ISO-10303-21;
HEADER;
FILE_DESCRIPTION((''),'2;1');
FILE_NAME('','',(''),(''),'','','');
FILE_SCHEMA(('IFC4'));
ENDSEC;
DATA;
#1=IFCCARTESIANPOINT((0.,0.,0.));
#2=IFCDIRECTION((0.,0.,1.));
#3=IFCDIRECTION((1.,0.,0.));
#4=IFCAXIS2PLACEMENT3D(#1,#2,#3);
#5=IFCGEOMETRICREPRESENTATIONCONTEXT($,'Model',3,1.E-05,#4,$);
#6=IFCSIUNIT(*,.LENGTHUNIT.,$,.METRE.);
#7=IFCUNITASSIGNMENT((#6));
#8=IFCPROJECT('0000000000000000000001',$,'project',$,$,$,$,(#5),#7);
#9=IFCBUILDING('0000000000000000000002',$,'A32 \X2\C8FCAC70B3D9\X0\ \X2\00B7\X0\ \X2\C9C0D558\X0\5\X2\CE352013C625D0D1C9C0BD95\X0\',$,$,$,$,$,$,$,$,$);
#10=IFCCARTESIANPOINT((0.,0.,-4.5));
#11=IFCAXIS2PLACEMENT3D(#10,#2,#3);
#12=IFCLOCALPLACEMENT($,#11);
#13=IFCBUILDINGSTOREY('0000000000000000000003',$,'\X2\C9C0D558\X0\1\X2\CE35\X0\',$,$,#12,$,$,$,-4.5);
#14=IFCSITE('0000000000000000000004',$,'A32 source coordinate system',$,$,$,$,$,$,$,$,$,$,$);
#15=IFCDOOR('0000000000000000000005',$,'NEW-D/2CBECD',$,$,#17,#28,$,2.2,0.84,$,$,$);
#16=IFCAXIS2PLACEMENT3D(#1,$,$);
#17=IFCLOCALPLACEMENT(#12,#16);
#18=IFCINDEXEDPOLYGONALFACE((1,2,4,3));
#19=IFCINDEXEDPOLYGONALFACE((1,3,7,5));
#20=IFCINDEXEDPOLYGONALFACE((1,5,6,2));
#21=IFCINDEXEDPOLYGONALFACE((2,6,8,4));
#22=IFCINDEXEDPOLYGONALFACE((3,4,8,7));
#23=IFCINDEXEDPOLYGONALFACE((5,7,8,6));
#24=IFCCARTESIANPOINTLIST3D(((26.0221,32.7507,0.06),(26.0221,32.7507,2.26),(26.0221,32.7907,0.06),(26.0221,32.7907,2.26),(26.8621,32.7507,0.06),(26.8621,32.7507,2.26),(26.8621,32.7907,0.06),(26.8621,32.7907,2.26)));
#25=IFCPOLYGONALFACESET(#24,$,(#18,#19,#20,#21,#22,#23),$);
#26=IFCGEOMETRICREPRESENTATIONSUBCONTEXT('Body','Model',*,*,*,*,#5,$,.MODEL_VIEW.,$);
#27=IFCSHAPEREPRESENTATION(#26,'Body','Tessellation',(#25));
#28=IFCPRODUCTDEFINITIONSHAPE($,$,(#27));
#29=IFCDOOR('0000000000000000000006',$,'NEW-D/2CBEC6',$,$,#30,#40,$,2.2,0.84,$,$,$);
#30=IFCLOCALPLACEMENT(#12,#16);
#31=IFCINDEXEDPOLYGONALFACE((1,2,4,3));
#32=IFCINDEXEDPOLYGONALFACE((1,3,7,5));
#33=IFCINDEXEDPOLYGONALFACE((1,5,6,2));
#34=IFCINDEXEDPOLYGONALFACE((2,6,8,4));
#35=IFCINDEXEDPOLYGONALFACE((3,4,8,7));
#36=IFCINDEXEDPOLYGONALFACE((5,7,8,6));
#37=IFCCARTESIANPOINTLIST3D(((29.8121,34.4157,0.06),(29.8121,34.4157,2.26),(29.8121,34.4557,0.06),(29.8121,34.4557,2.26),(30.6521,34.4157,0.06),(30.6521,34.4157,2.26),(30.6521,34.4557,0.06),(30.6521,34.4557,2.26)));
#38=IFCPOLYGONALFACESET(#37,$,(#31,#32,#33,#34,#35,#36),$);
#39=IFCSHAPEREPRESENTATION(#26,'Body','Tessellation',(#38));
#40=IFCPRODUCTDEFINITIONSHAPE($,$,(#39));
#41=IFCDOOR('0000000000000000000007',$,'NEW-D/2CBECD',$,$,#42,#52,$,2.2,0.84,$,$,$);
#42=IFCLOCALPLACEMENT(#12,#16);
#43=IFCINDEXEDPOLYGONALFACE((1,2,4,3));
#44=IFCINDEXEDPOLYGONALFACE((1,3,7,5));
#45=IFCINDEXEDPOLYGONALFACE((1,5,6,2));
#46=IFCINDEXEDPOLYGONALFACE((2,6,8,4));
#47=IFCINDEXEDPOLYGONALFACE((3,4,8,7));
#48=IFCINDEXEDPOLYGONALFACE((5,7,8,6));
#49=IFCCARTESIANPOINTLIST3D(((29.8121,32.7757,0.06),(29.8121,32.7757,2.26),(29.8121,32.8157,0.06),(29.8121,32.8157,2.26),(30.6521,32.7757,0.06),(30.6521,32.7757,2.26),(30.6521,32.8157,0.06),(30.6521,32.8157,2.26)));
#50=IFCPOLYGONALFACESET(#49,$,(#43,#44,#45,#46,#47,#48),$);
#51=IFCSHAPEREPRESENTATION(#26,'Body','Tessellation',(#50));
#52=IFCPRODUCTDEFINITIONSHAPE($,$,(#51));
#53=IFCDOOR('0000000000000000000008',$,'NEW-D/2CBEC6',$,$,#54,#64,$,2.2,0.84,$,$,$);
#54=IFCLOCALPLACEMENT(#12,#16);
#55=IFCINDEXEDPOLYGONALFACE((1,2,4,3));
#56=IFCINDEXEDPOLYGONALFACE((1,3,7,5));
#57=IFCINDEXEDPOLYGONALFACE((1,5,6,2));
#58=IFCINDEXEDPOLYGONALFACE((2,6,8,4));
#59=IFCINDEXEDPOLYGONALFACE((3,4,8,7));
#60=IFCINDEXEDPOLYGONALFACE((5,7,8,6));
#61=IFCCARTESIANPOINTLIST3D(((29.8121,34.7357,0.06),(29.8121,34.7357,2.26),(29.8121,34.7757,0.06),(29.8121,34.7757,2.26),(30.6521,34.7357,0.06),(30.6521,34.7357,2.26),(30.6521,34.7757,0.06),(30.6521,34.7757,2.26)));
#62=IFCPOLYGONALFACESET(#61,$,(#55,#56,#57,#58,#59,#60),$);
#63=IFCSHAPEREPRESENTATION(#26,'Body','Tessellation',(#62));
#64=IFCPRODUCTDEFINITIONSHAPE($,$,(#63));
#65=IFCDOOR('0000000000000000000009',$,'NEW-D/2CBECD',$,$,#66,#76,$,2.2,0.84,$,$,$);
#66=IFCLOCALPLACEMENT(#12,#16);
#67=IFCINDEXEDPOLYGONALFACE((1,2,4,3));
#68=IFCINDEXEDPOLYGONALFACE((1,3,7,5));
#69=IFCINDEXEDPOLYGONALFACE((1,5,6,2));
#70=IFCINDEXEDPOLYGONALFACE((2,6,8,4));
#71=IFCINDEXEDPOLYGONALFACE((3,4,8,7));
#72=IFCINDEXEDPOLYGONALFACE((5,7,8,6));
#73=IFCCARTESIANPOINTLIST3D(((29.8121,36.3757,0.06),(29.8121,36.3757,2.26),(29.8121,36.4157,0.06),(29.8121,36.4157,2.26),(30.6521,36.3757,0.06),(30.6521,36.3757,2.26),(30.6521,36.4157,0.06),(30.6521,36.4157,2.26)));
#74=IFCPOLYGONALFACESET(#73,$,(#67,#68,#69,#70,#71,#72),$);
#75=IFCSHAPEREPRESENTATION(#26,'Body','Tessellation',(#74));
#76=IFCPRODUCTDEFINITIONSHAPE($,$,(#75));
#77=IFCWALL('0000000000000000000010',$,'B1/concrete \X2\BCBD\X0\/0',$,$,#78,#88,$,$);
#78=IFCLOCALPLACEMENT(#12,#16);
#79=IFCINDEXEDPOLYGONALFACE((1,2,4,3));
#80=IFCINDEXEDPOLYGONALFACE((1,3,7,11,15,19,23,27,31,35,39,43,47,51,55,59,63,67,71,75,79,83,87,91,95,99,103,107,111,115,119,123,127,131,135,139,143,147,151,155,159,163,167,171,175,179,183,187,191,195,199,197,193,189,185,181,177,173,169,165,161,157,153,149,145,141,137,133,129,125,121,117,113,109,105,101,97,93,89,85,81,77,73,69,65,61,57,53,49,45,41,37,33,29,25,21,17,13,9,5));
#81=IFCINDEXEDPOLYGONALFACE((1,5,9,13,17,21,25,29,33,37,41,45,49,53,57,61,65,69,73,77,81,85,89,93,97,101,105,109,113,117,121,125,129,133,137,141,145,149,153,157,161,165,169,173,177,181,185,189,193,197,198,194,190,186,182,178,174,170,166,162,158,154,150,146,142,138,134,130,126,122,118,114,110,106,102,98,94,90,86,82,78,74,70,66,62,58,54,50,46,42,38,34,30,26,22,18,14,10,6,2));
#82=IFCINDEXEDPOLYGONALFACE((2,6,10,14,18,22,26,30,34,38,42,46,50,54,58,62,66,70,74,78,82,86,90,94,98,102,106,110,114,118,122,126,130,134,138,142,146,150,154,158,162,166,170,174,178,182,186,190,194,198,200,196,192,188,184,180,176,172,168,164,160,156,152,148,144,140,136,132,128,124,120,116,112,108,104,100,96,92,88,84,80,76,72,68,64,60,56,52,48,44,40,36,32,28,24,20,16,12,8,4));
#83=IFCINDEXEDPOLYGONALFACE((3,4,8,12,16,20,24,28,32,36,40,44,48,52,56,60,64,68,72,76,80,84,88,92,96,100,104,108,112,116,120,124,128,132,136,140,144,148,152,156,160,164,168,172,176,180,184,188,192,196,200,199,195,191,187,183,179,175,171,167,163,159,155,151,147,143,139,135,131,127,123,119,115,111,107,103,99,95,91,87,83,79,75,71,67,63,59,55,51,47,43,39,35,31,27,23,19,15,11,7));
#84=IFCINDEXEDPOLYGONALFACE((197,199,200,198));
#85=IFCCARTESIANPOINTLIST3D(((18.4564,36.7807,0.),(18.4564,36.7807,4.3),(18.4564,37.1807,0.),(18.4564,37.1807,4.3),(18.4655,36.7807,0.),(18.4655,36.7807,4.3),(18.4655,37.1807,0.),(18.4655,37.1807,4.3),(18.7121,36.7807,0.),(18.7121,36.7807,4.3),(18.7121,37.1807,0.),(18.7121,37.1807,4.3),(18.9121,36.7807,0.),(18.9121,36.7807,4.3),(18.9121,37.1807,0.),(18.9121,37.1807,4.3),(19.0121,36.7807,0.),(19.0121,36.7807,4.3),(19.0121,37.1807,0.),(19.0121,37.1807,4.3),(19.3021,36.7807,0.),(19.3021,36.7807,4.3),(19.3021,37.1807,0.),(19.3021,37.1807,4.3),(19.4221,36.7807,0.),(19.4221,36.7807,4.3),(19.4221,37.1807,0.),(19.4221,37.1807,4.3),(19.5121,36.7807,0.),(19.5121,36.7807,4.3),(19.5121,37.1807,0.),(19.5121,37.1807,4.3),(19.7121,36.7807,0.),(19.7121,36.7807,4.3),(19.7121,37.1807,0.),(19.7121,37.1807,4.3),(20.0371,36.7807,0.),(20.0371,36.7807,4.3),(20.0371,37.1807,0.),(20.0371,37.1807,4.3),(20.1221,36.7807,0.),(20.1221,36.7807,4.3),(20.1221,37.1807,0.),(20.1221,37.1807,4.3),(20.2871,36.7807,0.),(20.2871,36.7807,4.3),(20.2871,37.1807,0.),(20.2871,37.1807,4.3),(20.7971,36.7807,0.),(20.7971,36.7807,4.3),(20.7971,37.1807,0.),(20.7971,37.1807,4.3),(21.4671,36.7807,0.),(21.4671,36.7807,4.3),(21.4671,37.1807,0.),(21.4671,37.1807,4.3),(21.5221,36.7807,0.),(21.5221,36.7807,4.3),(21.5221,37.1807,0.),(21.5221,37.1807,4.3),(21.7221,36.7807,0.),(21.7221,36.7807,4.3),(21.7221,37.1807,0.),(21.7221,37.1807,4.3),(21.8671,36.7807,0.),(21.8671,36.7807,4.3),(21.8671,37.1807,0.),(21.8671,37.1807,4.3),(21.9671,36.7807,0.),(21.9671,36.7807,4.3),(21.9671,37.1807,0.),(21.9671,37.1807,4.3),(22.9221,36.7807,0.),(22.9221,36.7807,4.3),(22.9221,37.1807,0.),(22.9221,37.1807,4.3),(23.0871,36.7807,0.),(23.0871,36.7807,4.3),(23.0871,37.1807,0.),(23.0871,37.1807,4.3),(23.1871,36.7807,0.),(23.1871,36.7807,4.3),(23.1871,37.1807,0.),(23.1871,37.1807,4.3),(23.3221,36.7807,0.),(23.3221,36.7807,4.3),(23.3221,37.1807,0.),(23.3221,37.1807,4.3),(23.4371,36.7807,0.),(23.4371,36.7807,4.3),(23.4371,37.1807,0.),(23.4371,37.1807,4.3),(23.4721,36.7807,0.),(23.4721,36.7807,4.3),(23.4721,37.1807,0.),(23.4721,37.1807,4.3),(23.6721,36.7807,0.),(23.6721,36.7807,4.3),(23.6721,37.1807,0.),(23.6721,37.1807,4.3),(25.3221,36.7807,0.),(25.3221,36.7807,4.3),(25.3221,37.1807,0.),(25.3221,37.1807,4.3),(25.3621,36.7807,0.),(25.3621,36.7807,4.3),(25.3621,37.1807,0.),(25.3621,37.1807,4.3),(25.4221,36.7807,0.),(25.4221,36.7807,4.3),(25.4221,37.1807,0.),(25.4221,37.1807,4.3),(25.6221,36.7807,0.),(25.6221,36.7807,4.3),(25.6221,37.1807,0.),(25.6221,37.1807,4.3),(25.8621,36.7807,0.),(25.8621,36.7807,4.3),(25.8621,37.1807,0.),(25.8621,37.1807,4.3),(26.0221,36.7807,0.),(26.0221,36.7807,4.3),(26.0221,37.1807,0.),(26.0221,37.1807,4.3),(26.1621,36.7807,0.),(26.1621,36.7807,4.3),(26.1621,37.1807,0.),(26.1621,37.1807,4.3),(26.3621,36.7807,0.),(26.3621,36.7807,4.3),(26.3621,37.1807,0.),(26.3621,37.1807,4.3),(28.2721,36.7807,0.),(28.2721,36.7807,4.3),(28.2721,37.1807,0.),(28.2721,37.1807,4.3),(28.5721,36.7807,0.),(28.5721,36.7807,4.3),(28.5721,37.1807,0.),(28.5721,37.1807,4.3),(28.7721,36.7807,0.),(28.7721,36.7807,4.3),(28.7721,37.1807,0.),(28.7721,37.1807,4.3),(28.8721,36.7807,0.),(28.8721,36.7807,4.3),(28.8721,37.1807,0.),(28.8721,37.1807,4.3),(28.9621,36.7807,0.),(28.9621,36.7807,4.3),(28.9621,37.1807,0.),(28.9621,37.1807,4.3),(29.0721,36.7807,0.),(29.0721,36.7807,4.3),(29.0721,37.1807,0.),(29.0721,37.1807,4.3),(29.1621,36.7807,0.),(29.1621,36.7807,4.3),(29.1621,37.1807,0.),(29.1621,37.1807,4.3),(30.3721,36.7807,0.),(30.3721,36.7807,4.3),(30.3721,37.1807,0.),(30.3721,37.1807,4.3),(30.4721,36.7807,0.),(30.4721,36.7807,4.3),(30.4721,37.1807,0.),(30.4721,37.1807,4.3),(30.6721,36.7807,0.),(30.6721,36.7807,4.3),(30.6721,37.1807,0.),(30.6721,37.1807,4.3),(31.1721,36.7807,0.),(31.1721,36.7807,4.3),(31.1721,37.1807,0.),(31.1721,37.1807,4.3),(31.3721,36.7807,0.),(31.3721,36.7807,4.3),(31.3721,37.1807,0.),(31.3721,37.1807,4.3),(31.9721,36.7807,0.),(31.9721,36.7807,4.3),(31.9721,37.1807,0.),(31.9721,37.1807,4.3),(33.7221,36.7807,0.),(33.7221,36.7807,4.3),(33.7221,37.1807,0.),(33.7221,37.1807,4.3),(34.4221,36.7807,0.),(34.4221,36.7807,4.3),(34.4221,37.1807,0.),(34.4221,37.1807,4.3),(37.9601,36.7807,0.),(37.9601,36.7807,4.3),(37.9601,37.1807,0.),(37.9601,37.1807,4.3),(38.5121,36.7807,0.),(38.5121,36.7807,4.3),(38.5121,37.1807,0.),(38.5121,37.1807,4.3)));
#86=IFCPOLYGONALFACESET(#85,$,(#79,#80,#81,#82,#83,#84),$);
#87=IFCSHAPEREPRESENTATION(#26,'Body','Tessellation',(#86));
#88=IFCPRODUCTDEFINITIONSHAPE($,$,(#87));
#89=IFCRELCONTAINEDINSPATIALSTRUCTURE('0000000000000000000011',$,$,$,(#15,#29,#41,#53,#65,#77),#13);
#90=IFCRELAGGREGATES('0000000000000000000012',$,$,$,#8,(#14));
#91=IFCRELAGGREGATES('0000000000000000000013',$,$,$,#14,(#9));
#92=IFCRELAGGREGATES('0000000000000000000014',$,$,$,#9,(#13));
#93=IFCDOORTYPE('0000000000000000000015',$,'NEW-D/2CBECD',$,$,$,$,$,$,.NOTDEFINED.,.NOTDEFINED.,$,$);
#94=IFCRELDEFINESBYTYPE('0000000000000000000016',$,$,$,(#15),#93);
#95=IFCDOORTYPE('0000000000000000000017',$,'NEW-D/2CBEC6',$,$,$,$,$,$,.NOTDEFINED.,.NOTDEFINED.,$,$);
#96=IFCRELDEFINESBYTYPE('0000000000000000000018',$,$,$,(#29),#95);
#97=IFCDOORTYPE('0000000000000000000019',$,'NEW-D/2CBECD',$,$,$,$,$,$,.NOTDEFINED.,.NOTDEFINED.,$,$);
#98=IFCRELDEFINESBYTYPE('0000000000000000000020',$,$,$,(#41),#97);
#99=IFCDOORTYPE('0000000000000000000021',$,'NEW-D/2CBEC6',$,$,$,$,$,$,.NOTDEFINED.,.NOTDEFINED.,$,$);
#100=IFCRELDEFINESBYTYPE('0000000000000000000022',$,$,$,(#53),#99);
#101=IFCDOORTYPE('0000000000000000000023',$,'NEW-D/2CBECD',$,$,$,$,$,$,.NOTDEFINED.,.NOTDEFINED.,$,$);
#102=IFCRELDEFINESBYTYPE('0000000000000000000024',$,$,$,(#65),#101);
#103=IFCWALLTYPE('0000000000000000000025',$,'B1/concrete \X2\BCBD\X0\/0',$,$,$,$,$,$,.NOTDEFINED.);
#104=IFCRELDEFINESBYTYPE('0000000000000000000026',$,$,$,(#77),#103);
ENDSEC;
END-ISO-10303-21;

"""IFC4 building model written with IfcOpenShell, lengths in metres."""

from ifc_helpers import new_model, si_unit, frame, origin, origin_with_axes, place, context, subcontext, project, spatial, polyline, outline, extrude, source, transform, mapped, type_object, type_shapes, element, save


model = new_model("IFC4")

# Units and contexts
model_context = context("Model", 3, precision=1e-05, world=origin_with_axes())
body_context = subcontext(model_context, "Body", "Model", "MODEL_VIEW")
ifc_project = project(units=[si_unit("LENGTHUNIT", "METRE")], contexts=[model_context])

# Site, building, storey
storey_placement = place(None, frame((0.0, 0.0, -4.5), z_axis=(0.0, 0.0, 1.0), x_axis=(1.0, 0.0, 0.0)))
site = spatial("IfcSite", under=ifc_project, Name="A32 source coordinate system")
building = spatial("IfcBuilding", under=site, Name="A32 주거동 · 지하5층–옥탑지붕")
storey = spatial("IfcBuildingStorey", under=building, at=storey_placement, Name="지하1층", Elevation=-4.5)

# Doors
door_type_1 = type_object("IfcDoorType", Name="NEW-D/2CBECD", OperationType="NOTDEFINED", PredefinedType="NOTDEFINED")
shared_shape_1 = source(origin(), body_context, "Body", "SweptSolid", [
    extrude(outline(polyline([(26.8621, 32.7507), (26.0221, 32.7507), (26.0221, 32.7907), (26.8621, 32.7907), (26.8621, 32.7507)])), frame((0.0, 0.0, 0.06)), (0.0, 0.0, 1.0), 2.2),
])
type_shapes(door_type_1, [shared_shape_1])
door_1_placement = place(storey_placement, origin_with_axes())
element("IfcDoor", 1, at=door_1_placement, inside=storey, type_object=door_type_1, Name="NEW-D/2CBECD", OverallHeight=2.2, OverallWidth=0.84, context=body_context, shape_type="MappedRepresentation", body=[
    mapped(shared_shape_1, transform((0.0, 0.0, 0.0), scale=1.0)),
])
door_type_2 = type_object("IfcDoorType", Name="NEW-D/2CBEC6", OperationType="NOTDEFINED", PredefinedType="NOTDEFINED")
shared_shape_2 = source(origin(), body_context, "Body", "SweptSolid", [
    extrude(outline(polyline([(29.8121, 34.4557), (30.6521, 34.4557), (30.6521, 34.4157), (29.8121, 34.4157), (29.8121, 34.4557)])), frame((0.0, 0.0, 0.06)), (0.0, 0.0, 1.0), 2.2),
])
type_shapes(door_type_2, [shared_shape_2])
door_2_placement = place(storey_placement, origin_with_axes())
element("IfcDoor", 2, at=door_2_placement, inside=storey, type_object=door_type_2, Name="NEW-D/2CBEC6", OverallHeight=2.2, OverallWidth=0.84, context=body_context, shape_type="MappedRepresentation", body=[
    mapped(shared_shape_2, transform((0.0, 0.0, 0.0), scale=1.0)),
])
door_type_3 = type_object("IfcDoorType", Name="NEW-D/2CBECD", OperationType="NOTDEFINED", PredefinedType="NOTDEFINED")
shared_shape_3 = source(origin(), body_context, "Body", "SweptSolid", [
    extrude(outline(polyline([(30.6521, 32.8157), (30.6521, 32.7757), (29.8121, 32.7757), (29.8121, 32.8157), (30.6521, 32.8157)])), frame((0.0, 0.0, 0.06)), (0.0, 0.0, 1.0), 2.2),
])
type_shapes(door_type_3, [shared_shape_3])
door_3_placement = place(storey_placement, origin_with_axes())
element("IfcDoor", 3, at=door_3_placement, inside=storey, type_object=door_type_3, Name="NEW-D/2CBECD", OverallHeight=2.2, OverallWidth=0.84, context=body_context, shape_type="MappedRepresentation", body=[
    mapped(shared_shape_3, transform((0.0, 0.0, 0.0), scale=1.0)),
])
door_type_4 = type_object("IfcDoorType", Name="NEW-D/2CBEC6", OperationType="NOTDEFINED", PredefinedType="NOTDEFINED")
shared_shape_4 = source(origin(), body_context, "Body", "SweptSolid", [
    extrude(outline(polyline([(30.6521, 34.7757), (30.6521, 34.7357), (29.8121, 34.7357), (29.8121, 34.7757), (30.6521, 34.7757)])), frame((0.0, 0.0, 0.06)), (0.0, 0.0, 1.0), 2.2),
])
type_shapes(door_type_4, [shared_shape_4])
door_4_placement = place(storey_placement, origin_with_axes())
element("IfcDoor", 4, at=door_4_placement, inside=storey, type_object=door_type_4, Name="NEW-D/2CBEC6", OverallHeight=2.2, OverallWidth=0.84, context=body_context, shape_type="MappedRepresentation", body=[
    mapped(shared_shape_4, transform((0.0, 0.0, 0.0), scale=1.0)),
])
door_type_5 = type_object("IfcDoorType", Name="NEW-D/2CBECD", OperationType="NOTDEFINED", PredefinedType="NOTDEFINED")
shared_shape_5 = source(origin(), body_context, "Body", "SweptSolid", [
    extrude(outline(polyline([(29.8121, 36.4157), (30.6521, 36.4157), (30.6521, 36.3757), (29.8121, 36.3757), (29.8121, 36.4157)])), frame((0.0, 0.0, 0.06)), (0.0, 0.0, 1.0), 2.2),
])
type_shapes(door_type_5, [shared_shape_5])
door_5_placement = place(storey_placement, origin_with_axes())
element("IfcDoor", 5, at=door_5_placement, inside=storey, type_object=door_type_5, Name="NEW-D/2CBECD", OverallHeight=2.2, OverallWidth=0.84, context=body_context, shape_type="MappedRepresentation", body=[
    mapped(shared_shape_5, transform((0.0, 0.0, 0.0), scale=1.0)),
])

# Wall
wall_type = type_object("IfcWallType", Name="B1/concrete 벽/0", PredefinedType="NOTDEFINED")
shared_shape_6 = source(origin(), body_context, "Body", "SweptSolid", [
    extrude(outline(polyline([(18.4655, 36.7807), (18.4564, 36.7807), (18.4564, 37.1807), (18.4655, 37.1807), (18.7121, 37.1807), (18.9121, 37.1807), (19.0121, 37.1807), (19.3021, 37.1807), (19.4221, 37.1807), (19.5121, 37.1807), (19.7121, 37.1807), (20.0371, 37.1807), (20.1221, 37.1807), (20.2871, 37.1807), (20.7971, 37.1807), (21.4671, 37.1807), (21.5221, 37.1807), (21.7221, 37.1807), (21.8671, 37.1807), (21.9671, 37.1807), (22.9221, 37.1807), (23.0871, 37.1807), (23.1871, 37.1807), (23.3221, 37.1807), (23.4371, 37.1807), (23.4721, 37.1807), (23.6721, 37.1807), (25.3221, 37.1807), (25.3621, 37.1807), (25.4221, 37.1807), (25.6221, 37.1807), (25.8621, 37.1807), (26.0221, 37.1807), (26.1621, 37.1807), (26.3621, 37.1807), (28.2721, 37.1807), (28.5721, 37.1807), (28.7721, 37.1807), (28.8721, 37.1807), (28.9621, 37.1807), (29.0721, 37.1807), (29.1621, 37.1807), (30.3721, 37.1807), (30.4721, 37.1807), (30.6721, 37.1807), (31.1721, 37.1807), (31.3721, 37.1807), (31.9721, 37.1807), (33.7221, 37.1807), (34.4221, 37.1807), (37.9601, 37.1807), (38.5121, 37.1807), (38.5121, 36.7807), (37.9601, 36.7807), (34.4221, 36.7807), (33.7221, 36.7807), (31.9721, 36.7807), (31.3721, 36.7807), (31.1721, 36.7807), (30.6721, 36.7807), (30.4721, 36.7807), (30.3721, 36.7807), (29.1621, 36.7807), (29.0721, 36.7807), (28.9621, 36.7807), (28.8721, 36.7807), (28.7721, 36.7807), (28.5721, 36.7807), (28.2721, 36.7807), (26.3621, 36.7807), (26.1621, 36.7807), (26.0221, 36.7807), (25.8621, 36.7807), (25.6221, 36.7807), (25.4221, 36.7807), (25.3621, 36.7807), (25.3221, 36.7807), (23.6721, 36.7807), (23.4721, 36.7807), (23.4371, 36.7807), (23.3221, 36.7807), (23.1871, 36.7807), (23.0871, 36.7807), (22.9221, 36.7807), (21.9671, 36.7807), (21.8671, 36.7807), (21.7221, 36.7807), (21.5221, 36.7807), (21.4671, 36.7807), (20.7971, 36.7807), (20.2871, 36.7807), (20.1221, 36.7807), (20.0371, 36.7807), (19.7121, 36.7807), (19.5121, 36.7807), (19.4221, 36.7807), (19.3021, 36.7807), (19.0121, 36.7807), (18.9121, 36.7807), (18.7121, 36.7807), (18.4655, 36.7807)])), origin(), (0.0, 0.0, 1.0), 4.3),
])
type_shapes(wall_type, [shared_shape_6])
wall_placement = place(storey_placement, origin_with_axes())
element("IfcWall", 6, at=wall_placement, inside=storey, type_object=wall_type, Name="B1/concrete 벽/0", context=body_context, shape_type="MappedRepresentation", body=[
    mapped(shared_shape_6, transform((0.0, 0.0, 0.0), scale=1.0)),
])

save(model, "model.ifc")
